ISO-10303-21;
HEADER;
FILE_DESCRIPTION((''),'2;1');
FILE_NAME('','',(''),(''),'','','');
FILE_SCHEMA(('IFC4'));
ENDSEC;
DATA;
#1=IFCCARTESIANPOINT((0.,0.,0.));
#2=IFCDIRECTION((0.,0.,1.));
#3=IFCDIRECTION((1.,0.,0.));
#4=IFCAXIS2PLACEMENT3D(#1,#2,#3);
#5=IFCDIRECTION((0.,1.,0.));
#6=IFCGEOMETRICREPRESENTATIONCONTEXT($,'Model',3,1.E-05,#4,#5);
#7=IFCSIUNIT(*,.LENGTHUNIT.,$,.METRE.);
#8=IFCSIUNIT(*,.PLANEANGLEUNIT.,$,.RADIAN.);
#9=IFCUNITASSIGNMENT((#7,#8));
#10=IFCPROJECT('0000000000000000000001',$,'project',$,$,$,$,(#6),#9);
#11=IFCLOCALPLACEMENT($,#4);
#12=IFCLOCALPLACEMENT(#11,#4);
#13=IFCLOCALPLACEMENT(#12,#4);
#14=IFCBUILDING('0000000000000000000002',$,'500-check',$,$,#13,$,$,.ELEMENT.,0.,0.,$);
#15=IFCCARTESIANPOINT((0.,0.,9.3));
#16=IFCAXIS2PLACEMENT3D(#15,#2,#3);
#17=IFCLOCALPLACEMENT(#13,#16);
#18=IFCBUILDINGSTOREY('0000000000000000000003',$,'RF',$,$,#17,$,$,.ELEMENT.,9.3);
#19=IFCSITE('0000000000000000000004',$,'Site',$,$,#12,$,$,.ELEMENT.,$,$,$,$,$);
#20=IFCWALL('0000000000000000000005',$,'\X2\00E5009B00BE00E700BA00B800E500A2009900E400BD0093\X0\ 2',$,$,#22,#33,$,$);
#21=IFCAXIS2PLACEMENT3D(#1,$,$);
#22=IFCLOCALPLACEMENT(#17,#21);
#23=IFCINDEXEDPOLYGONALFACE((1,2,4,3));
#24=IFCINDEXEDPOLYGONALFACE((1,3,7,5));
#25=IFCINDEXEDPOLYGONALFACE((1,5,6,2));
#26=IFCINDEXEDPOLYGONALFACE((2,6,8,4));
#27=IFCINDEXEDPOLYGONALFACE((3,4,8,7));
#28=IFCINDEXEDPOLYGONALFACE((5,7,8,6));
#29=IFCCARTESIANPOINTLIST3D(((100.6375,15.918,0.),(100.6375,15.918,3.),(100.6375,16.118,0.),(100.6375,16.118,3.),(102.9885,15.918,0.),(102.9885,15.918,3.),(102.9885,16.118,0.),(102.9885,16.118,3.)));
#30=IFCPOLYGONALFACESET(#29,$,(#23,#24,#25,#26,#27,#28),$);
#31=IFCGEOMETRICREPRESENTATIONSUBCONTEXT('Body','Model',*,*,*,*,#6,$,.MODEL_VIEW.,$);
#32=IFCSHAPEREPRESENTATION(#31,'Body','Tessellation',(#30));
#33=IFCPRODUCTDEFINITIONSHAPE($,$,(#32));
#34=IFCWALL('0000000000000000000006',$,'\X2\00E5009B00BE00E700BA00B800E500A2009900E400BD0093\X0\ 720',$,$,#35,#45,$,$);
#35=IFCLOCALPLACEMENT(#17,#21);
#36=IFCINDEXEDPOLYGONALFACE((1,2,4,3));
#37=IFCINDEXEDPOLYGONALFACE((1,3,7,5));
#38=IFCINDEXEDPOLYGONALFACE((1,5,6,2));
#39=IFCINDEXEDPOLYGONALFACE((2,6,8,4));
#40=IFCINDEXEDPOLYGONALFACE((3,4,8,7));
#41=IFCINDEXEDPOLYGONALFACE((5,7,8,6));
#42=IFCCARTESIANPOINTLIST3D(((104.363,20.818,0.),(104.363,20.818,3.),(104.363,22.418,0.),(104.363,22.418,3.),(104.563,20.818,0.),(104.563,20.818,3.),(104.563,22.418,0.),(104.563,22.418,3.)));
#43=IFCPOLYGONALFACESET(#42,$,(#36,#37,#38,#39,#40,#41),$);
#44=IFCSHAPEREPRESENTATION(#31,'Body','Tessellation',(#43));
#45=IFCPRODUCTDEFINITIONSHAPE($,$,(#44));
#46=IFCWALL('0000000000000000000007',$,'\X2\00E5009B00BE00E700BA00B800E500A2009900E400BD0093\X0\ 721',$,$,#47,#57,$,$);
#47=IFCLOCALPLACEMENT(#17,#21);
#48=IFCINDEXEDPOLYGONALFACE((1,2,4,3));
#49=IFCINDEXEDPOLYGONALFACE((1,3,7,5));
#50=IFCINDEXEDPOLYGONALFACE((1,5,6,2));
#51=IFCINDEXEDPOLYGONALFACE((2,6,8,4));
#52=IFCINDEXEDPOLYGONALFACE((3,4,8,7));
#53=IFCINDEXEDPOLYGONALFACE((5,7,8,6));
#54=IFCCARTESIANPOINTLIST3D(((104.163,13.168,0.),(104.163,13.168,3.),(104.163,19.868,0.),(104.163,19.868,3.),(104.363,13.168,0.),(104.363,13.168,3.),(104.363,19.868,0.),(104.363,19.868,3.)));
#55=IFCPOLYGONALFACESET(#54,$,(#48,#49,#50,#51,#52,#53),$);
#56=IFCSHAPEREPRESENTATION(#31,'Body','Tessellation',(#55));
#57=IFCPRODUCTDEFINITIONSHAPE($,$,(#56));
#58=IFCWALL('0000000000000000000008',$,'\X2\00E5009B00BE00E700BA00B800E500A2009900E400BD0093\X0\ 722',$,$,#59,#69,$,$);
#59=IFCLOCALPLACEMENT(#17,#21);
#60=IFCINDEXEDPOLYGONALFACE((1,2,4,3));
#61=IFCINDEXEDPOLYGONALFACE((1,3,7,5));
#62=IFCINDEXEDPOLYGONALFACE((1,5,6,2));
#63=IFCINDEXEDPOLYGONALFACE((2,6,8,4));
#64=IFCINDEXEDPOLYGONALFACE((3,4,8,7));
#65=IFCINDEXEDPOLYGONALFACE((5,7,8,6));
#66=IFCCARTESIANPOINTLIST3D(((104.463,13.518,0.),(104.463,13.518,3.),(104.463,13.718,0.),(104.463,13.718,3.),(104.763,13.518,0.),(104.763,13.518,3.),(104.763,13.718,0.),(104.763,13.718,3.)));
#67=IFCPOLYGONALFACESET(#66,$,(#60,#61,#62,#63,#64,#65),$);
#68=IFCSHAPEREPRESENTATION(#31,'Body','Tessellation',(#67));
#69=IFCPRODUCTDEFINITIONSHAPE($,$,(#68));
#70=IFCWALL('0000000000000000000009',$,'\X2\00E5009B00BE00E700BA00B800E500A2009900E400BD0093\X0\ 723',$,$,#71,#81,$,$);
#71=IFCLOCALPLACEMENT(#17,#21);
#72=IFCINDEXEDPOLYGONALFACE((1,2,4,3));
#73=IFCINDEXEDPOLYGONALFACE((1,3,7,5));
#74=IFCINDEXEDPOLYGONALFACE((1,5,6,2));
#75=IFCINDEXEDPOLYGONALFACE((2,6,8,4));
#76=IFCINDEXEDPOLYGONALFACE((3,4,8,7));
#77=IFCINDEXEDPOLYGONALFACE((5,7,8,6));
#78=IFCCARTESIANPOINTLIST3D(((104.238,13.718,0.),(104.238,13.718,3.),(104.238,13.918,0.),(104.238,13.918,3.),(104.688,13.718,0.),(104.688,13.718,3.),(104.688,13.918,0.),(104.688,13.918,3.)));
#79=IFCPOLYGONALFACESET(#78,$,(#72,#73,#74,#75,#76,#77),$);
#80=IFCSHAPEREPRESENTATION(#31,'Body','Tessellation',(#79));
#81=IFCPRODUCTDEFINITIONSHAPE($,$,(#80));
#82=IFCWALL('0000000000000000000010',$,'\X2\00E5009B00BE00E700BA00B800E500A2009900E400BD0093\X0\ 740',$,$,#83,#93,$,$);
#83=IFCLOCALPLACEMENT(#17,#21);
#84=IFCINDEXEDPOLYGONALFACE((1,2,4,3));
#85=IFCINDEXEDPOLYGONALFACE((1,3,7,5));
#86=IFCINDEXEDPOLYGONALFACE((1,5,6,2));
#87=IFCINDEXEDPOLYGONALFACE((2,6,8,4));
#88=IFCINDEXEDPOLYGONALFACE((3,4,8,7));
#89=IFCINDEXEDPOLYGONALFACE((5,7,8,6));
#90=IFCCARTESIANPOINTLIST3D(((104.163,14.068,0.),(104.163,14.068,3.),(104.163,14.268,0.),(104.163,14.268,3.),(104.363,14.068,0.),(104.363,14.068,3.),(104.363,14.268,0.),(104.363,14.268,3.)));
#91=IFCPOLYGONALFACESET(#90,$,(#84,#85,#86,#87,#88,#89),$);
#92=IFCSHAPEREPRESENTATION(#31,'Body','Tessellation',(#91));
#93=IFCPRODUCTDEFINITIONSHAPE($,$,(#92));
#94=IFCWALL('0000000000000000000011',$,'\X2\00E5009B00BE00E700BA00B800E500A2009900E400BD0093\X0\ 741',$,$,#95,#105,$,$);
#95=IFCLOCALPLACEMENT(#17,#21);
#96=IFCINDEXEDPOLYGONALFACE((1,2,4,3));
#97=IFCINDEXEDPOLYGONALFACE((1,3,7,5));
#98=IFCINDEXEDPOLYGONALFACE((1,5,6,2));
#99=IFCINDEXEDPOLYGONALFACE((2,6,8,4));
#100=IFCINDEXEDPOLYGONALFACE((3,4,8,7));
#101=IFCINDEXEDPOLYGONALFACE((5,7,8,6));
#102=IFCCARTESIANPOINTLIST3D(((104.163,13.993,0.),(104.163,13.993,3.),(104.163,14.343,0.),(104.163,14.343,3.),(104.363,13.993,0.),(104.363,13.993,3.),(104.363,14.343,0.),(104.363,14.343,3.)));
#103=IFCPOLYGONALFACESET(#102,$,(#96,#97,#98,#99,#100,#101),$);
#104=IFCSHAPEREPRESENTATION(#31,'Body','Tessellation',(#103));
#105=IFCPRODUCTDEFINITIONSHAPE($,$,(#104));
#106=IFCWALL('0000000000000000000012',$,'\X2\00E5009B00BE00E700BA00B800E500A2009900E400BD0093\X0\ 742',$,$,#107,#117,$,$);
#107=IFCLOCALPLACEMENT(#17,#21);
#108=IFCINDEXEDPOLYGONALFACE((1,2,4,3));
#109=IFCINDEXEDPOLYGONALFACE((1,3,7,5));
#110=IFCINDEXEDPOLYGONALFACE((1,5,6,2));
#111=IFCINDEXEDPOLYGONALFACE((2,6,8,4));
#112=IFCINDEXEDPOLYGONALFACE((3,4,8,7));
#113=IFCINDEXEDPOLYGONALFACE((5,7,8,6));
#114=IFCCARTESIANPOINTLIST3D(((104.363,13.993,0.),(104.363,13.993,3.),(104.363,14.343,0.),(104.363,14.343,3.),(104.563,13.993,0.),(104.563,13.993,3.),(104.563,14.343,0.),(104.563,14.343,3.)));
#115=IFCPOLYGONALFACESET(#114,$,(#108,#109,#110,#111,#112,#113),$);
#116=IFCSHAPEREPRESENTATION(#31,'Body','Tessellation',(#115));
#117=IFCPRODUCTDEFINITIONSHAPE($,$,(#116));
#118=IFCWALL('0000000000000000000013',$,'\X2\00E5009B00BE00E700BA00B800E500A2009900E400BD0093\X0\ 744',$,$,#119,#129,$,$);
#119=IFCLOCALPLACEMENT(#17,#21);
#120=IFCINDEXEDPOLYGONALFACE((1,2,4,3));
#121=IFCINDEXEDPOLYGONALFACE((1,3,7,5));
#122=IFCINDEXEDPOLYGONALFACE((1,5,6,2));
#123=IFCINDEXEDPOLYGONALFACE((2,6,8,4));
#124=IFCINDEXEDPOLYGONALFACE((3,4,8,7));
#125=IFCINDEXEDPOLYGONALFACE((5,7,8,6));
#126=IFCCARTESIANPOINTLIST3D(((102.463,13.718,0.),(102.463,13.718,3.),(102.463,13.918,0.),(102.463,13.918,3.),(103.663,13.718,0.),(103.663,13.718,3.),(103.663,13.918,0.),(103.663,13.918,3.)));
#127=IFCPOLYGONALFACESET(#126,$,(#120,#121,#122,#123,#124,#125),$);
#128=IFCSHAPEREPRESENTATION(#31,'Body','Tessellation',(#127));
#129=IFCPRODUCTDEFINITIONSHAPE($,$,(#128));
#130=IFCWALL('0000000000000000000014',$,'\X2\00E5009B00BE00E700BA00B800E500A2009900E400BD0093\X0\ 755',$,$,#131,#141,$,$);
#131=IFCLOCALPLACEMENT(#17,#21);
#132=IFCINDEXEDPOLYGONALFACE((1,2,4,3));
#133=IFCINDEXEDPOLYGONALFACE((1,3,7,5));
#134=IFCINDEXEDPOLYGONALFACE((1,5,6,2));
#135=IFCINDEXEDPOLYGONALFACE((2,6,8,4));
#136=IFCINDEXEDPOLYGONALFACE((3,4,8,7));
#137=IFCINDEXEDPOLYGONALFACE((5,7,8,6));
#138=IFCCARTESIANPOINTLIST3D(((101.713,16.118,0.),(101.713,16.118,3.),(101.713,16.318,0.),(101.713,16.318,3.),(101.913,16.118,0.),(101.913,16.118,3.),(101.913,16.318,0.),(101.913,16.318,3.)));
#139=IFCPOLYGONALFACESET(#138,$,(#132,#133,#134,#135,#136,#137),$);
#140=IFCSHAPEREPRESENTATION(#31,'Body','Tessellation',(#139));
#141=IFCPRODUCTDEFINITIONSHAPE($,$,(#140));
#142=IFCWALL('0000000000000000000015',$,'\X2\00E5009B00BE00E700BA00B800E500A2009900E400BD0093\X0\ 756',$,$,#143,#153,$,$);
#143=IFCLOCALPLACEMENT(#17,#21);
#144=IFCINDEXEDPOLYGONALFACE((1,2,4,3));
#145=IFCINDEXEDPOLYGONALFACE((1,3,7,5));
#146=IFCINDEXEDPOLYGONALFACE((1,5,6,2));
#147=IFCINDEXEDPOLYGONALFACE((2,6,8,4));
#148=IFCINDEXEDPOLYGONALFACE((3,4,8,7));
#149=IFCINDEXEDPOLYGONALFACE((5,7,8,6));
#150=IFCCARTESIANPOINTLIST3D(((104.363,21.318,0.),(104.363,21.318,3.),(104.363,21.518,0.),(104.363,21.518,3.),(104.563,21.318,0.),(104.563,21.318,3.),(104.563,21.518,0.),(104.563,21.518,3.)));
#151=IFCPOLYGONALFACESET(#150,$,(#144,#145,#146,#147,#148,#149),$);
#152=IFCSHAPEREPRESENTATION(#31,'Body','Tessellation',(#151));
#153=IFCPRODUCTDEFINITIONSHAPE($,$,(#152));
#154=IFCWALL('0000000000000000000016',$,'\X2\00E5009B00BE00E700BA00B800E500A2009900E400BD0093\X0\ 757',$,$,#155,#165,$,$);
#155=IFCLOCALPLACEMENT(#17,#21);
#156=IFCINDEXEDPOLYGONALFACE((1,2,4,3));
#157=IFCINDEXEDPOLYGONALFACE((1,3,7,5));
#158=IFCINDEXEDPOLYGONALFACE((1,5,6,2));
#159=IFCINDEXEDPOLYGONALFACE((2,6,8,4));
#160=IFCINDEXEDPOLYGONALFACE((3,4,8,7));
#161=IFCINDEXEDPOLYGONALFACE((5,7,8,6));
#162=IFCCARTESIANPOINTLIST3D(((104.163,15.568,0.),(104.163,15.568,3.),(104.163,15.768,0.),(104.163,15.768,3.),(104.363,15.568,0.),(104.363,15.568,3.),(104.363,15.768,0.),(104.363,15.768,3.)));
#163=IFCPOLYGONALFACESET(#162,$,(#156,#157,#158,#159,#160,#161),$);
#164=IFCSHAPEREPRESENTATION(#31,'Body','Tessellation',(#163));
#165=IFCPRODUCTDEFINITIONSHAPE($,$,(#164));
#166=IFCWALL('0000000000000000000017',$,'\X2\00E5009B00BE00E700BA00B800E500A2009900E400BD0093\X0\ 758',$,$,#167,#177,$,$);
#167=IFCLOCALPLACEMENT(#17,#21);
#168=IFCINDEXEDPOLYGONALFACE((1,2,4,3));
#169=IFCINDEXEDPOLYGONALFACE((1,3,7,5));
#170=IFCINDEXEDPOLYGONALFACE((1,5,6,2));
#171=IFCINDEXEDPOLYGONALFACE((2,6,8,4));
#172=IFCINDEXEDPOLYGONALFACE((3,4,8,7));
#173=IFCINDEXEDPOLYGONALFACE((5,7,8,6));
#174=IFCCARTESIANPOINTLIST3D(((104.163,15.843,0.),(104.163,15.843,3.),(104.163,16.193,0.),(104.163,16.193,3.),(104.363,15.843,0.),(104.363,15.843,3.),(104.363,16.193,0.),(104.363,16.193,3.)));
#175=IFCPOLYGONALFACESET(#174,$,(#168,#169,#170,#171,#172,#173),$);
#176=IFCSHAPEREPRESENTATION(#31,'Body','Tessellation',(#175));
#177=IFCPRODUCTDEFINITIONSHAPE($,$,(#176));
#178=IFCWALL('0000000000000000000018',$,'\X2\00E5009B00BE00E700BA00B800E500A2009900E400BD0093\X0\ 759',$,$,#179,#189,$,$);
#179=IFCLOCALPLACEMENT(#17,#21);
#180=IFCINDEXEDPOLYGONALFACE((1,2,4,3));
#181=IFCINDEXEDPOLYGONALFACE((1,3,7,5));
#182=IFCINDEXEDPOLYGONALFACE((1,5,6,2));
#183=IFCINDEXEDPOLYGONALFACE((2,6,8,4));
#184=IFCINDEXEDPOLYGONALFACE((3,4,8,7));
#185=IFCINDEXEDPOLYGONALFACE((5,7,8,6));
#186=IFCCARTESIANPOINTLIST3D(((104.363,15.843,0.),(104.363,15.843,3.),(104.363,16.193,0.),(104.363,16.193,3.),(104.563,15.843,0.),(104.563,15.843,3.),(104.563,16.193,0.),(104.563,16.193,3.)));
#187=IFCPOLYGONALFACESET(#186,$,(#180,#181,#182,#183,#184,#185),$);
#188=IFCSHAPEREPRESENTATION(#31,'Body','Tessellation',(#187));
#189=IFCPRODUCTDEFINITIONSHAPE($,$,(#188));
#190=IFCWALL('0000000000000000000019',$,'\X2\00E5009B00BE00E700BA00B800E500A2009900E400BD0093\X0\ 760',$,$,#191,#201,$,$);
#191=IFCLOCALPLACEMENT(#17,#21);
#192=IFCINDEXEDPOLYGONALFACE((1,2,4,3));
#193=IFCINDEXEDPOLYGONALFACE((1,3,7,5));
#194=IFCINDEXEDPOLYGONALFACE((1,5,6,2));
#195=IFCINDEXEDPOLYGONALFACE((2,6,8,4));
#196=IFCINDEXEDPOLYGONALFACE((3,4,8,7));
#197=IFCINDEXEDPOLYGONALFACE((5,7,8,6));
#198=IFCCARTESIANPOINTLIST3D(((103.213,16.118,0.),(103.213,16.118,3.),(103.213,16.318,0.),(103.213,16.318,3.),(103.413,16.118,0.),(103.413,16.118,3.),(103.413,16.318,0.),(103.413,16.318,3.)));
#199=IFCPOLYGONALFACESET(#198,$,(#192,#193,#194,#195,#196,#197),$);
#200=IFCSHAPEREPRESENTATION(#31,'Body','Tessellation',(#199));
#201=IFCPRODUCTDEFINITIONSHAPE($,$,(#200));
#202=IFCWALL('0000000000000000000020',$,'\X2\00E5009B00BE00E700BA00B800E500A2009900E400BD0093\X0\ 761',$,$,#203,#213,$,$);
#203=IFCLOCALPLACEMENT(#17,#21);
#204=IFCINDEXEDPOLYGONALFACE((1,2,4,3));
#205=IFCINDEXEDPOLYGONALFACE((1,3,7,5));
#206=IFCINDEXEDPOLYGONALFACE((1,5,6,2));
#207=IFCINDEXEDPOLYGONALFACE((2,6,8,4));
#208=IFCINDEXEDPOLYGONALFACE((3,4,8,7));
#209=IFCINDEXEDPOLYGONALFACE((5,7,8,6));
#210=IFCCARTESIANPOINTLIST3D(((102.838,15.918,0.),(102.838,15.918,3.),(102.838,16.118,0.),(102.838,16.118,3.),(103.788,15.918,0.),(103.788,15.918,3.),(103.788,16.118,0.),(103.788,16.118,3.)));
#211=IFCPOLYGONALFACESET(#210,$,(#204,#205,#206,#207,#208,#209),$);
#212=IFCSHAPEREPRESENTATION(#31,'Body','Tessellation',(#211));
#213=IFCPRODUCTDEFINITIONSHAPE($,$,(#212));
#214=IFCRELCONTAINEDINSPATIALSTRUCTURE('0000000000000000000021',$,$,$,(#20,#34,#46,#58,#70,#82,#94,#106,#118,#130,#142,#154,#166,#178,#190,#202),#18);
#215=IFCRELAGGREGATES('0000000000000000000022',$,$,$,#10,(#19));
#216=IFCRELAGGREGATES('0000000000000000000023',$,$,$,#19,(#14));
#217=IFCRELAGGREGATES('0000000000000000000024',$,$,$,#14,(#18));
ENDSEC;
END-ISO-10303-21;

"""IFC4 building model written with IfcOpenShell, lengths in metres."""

from ifc_helpers import new_model, si_unit, direction, frame, frame_2d, origin_with_axes, place, context, subcontext, project, spatial, rectangle, extrude, element, save


model = new_model("IFC4")

# Units and contexts
model_context = context("Model", 3, precision=1e-05, world=origin_with_axes(), true_north=direction((0.0, 1.0, 0.0)))
body_context = subcontext(model_context, "Body", "Model", "MODEL_VIEW")
ifc_project = project(units=[si_unit("LENGTHUNIT", "METRE"), si_unit("PLANEANGLEUNIT", "RADIAN")], contexts=[model_context])

# Site, building, storey
placement = place(None, origin_with_axes())
site_placement = place(placement, origin_with_axes())
site = spatial("IfcSite", under=ifc_project, at=site_placement, Name="Site", CompositionType="ELEMENT")
building_placement = place(site_placement, origin_with_axes())
building = spatial("IfcBuilding", under=site, at=building_placement, Name="500-check", CompositionType="ELEMENT", ElevationOfRefHeight=0.0, ElevationOfTerrain=0.0)
storey_placement = place(building_placement, frame((0.0, 0.0, 9.3), z_axis=(0.0, 0.0, 1.0), x_axis=(1.0, 0.0, 0.0)))
storey = spatial("IfcBuildingStorey", under=building, at=storey_placement, Name="RF", CompositionType="ELEMENT", Elevation=9.3)

# Walls
wall_1_placement = place(storey_placement, frame((101.813, 16.018, 0.0), z_axis=(0.0, 0.0, 1.0), x_axis=(-1.0, 0.0, 0.0)))
element("IfcWall", 1, at=wall_1_placement, inside=storey, Name="å\u009b¾çº¸å¢\u0099ä½\u0093 2", context=body_context, shape_type="SweptSolid", body=[
    extrude(rectangle(XDim=2.351, YDim=0.2, at=frame_2d((0.0, 0.0), x_axis=(1.0, 0.0, 0.0))), frame((0.0, 0.0, 0.0), z_axis=(0.0, 0.0, 1.0)), (0.0, 0.0, 1.0), 3.0),
])
wall_2_placement = place(storey_placement, frame((104.463, 21.618, 0.0), z_axis=(0.0, 0.0, 1.0), x_axis=(0.0, 1.0, 0.0)))
element("IfcWall", 2, at=wall_2_placement, inside=storey, Name="å\u009b¾çº¸å¢\u0099ä½\u0093 720", context=body_context, shape_type="SweptSolid", body=[
    extrude(rectangle(XDim=1.6, YDim=0.2, at=frame_2d((0.0, 0.0), x_axis=(1.0, 0.0, 0.0))), frame((0.0, 0.0, 0.0), z_axis=(0.0, 0.0, 1.0)), (0.0, 0.0, 1.0), 3.0),
])
wall_3_placement = place(storey_placement, frame((104.263, 16.518, 0.0), z_axis=(0.0, 0.0, 1.0), x_axis=(0.0, 1.0, 0.0)))
element("IfcWall", 3, at=wall_3_placement, inside=storey, Name="å\u009b¾çº¸å¢\u0099ä½\u0093 721", context=body_context, shape_type="SweptSolid", body=[
    extrude(rectangle(XDim=6.7, YDim=0.2, at=frame_2d((0.0, 0.0), x_axis=(1.0, 0.0, 0.0))), frame((0.0, 0.0, 0.0), z_axis=(0.0, 0.0, 1.0)), (0.0, 0.0, 1.0), 3.0),
])
wall_4_placement = place(storey_placement, frame((104.613, 13.618, 0.0), z_axis=(0.0, 0.0, 1.0), x_axis=(1.0, 0.0, 0.0)))
element("IfcWall", 4, at=wall_4_placement, inside=storey, Name="å\u009b¾çº¸å¢\u0099ä½\u0093 722", context=body_context, shape_type="SweptSolid", body=[
    extrude(rectangle(XDim=0.3, YDim=0.2, at=frame_2d((0.0, 0.0), x_axis=(1.0, 0.0, 0.0))), frame((0.0, 0.0, 0.0), z_axis=(0.0, 0.0, 1.0)), (0.0, 0.0, 1.0), 3.0),
])
wall_5_placement = place(storey_placement, frame((104.463, 13.818, 0.0), z_axis=(0.0, 0.0, 1.0), x_axis=(1.0, 0.0, 0.0)))
element("IfcWall", 5, at=wall_5_placement, inside=storey, Name="å\u009b¾çº¸å¢\u0099ä½\u0093 723", context=body_context, shape_type="SweptSolid", body=[
    extrude(rectangle(XDim=0.45, YDim=0.2, at=frame_2d((0.0, 0.0), x_axis=(1.0, 0.0, 0.0))), frame((0.0, 0.0, 0.0), z_axis=(0.0, 0.0, 1.0)), (0.0, 0.0, 1.0), 3.0),
])
wall_6_placement = place(storey_placement, frame((104.263, 14.168, 0.0), z_axis=(0.0, 0.0, 1.0), x_axis=(1.0, 0.0, 0.0)))
element("IfcWall", 6, at=wall_6_placement, inside=storey, Name="å\u009b¾çº¸å¢\u0099ä½\u0093 740", context=body_context, shape_type="SweptSolid", body=[
    extrude(rectangle(XDim=0.2, YDim=0.2, at=frame_2d((0.0, 0.0), x_axis=(1.0, 0.0, 0.0))), frame((0.0, 0.0, 0.0), z_axis=(0.0, 0.0, 1.0)), (0.0, 0.0, 1.0), 3.0),
])
for number, where, z_axis, x_axis, name in (
    (7, (104.263, 14.168, 0.0), (0.0, 0.0, 1.0), (0.0, -1.0, 0.0), "å\u009b¾çº¸å¢\u0099ä½\u0093 741"),
    (8, (104.463, 14.168, 0.0), (0.0, 0.0, 1.0), (0.0, -1.0, 0.0), "å\u009b¾çº¸å¢\u0099ä½\u0093 742"),
):
    element("IfcWall", number, at=place(storey_placement, frame(where, z_axis=z_axis, x_axis=x_axis)), inside=storey, Name=name, context=body_context, shape_type="SweptSolid", body=[
        extrude(rectangle(XDim=0.35, YDim=0.2, at=frame_2d((0.0, 0.0), x_axis=(1.0, 0.0, 0.0))), frame((0.0, 0.0, 0.0), z_axis=(0.0, 0.0, 1.0)), (0.0, 0.0, 1.0), 3.0),
    ])
wall_7_placement = place(storey_placement, frame((103.063, 13.818, 0.0), z_axis=(0.0, 0.0, 1.0), x_axis=(1.0, 0.0, 0.0)))
element("IfcWall", 9, at=wall_7_placement, inside=storey, Name="å\u009b¾çº¸å¢\u0099ä½\u0093 744", context=body_context, shape_type="SweptSolid", body=[
    extrude(rectangle(XDim=1.2, YDim=0.2, at=frame_2d((0.0, 0.0), x_axis=(1.0, 0.0, 0.0))), frame((0.0, 0.0, 0.0), z_axis=(0.0, 0.0, 1.0)), (0.0, 0.0, 1.0), 3.0),
])
for number, where, z_axis, x_axis, name in (
    (10, (101.813, 16.218, 0.0), (0.0, 0.0, 1.0), (0.0, -1.0, 0.0), "å\u009b¾çº¸å¢\u0099ä½\u0093 755"),
    (11, (104.463, 21.418, 0.0), (0.0, 0.0, 1.0), (0.0, 1.0, 0.0), "å\u009b¾çº¸å¢\u0099ä½\u0093 756"),
    (12, (104.263, 15.668, 0.0), (0.0, 0.0, 1.0), (1.0, 0.0, 0.0), "å\u009b¾çº¸å¢\u0099ä½\u0093 757"),
):
    element("IfcWall", number, at=place(storey_placement, frame(where, z_axis=z_axis, x_axis=x_axis)), inside=storey, Name=name, context=body_context, shape_type="SweptSolid", body=[
        extrude(rectangle(XDim=0.2, YDim=0.2, at=frame_2d((0.0, 0.0), x_axis=(1.0, 0.0, 0.0))), frame((0.0, 0.0, 0.0), z_axis=(0.0, 0.0, 1.0)), (0.0, 0.0, 1.0), 3.0),
    ])
for number, where, z_axis, x_axis, name in (
    (13, (104.263, 16.018, 0.0), (0.0, 0.0, 1.0), (0.0, -1.0, 0.0), "å\u009b¾çº¸å¢\u0099ä½\u0093 758"),
    (14, (104.463, 16.018, 0.0), (0.0, 0.0, 1.0), (0.0, -1.0, 0.0), "å\u009b¾çº¸å¢\u0099ä½\u0093 759"),
):
    element("IfcWall", number, at=place(storey_placement, frame(where, z_axis=z_axis, x_axis=x_axis)), inside=storey, Name=name, context=body_context, shape_type="SweptSolid", body=[
        extrude(rectangle(XDim=0.35, YDim=0.2, at=frame_2d((0.0, 0.0), x_axis=(1.0, 0.0, 0.0))), frame((0.0, 0.0, 0.0), z_axis=(0.0, 0.0, 1.0)), (0.0, 0.0, 1.0), 3.0),
    ])
wall_8_placement = place(storey_placement, frame((103.313, 16.218, 0.0), z_axis=(0.0, 0.0, 1.0), x_axis=(0.0, -1.0, 0.0)))
element("IfcWall", 15, at=wall_8_placement, inside=storey, Name="å\u009b¾çº¸å¢\u0099ä½\u0093 760", context=body_context, shape_type="SweptSolid", body=[
    extrude(rectangle(XDim=0.2, YDim=0.2, at=frame_2d((0.0, 0.0), x_axis=(1.0, 0.0, 0.0))), frame((0.0, 0.0, 0.0), z_axis=(0.0, 0.0, 1.0)), (0.0, 0.0, 1.0), 3.0),
])
wall_9_placement = place(storey_placement, frame((103.313, 16.018, 0.0), z_axis=(0.0, 0.0, 1.0), x_axis=(1.0, 0.0, 0.0)))
element("IfcWall", 16, at=wall_9_placement, inside=storey, Name="å\u009b¾çº¸å¢\u0099ä½\u0093 761", context=body_context, shape_type="SweptSolid", body=[
    extrude(rectangle(XDim=0.95, YDim=0.2, at=frame_2d((0.0, 0.0), x_axis=(1.0, 0.0, 0.0))), frame((0.0, 0.0, 0.0), z_axis=(0.0, 0.0, 1.0)), (0.0, 0.0, 1.0), 3.0),
])

save(model, "model.ifc")
